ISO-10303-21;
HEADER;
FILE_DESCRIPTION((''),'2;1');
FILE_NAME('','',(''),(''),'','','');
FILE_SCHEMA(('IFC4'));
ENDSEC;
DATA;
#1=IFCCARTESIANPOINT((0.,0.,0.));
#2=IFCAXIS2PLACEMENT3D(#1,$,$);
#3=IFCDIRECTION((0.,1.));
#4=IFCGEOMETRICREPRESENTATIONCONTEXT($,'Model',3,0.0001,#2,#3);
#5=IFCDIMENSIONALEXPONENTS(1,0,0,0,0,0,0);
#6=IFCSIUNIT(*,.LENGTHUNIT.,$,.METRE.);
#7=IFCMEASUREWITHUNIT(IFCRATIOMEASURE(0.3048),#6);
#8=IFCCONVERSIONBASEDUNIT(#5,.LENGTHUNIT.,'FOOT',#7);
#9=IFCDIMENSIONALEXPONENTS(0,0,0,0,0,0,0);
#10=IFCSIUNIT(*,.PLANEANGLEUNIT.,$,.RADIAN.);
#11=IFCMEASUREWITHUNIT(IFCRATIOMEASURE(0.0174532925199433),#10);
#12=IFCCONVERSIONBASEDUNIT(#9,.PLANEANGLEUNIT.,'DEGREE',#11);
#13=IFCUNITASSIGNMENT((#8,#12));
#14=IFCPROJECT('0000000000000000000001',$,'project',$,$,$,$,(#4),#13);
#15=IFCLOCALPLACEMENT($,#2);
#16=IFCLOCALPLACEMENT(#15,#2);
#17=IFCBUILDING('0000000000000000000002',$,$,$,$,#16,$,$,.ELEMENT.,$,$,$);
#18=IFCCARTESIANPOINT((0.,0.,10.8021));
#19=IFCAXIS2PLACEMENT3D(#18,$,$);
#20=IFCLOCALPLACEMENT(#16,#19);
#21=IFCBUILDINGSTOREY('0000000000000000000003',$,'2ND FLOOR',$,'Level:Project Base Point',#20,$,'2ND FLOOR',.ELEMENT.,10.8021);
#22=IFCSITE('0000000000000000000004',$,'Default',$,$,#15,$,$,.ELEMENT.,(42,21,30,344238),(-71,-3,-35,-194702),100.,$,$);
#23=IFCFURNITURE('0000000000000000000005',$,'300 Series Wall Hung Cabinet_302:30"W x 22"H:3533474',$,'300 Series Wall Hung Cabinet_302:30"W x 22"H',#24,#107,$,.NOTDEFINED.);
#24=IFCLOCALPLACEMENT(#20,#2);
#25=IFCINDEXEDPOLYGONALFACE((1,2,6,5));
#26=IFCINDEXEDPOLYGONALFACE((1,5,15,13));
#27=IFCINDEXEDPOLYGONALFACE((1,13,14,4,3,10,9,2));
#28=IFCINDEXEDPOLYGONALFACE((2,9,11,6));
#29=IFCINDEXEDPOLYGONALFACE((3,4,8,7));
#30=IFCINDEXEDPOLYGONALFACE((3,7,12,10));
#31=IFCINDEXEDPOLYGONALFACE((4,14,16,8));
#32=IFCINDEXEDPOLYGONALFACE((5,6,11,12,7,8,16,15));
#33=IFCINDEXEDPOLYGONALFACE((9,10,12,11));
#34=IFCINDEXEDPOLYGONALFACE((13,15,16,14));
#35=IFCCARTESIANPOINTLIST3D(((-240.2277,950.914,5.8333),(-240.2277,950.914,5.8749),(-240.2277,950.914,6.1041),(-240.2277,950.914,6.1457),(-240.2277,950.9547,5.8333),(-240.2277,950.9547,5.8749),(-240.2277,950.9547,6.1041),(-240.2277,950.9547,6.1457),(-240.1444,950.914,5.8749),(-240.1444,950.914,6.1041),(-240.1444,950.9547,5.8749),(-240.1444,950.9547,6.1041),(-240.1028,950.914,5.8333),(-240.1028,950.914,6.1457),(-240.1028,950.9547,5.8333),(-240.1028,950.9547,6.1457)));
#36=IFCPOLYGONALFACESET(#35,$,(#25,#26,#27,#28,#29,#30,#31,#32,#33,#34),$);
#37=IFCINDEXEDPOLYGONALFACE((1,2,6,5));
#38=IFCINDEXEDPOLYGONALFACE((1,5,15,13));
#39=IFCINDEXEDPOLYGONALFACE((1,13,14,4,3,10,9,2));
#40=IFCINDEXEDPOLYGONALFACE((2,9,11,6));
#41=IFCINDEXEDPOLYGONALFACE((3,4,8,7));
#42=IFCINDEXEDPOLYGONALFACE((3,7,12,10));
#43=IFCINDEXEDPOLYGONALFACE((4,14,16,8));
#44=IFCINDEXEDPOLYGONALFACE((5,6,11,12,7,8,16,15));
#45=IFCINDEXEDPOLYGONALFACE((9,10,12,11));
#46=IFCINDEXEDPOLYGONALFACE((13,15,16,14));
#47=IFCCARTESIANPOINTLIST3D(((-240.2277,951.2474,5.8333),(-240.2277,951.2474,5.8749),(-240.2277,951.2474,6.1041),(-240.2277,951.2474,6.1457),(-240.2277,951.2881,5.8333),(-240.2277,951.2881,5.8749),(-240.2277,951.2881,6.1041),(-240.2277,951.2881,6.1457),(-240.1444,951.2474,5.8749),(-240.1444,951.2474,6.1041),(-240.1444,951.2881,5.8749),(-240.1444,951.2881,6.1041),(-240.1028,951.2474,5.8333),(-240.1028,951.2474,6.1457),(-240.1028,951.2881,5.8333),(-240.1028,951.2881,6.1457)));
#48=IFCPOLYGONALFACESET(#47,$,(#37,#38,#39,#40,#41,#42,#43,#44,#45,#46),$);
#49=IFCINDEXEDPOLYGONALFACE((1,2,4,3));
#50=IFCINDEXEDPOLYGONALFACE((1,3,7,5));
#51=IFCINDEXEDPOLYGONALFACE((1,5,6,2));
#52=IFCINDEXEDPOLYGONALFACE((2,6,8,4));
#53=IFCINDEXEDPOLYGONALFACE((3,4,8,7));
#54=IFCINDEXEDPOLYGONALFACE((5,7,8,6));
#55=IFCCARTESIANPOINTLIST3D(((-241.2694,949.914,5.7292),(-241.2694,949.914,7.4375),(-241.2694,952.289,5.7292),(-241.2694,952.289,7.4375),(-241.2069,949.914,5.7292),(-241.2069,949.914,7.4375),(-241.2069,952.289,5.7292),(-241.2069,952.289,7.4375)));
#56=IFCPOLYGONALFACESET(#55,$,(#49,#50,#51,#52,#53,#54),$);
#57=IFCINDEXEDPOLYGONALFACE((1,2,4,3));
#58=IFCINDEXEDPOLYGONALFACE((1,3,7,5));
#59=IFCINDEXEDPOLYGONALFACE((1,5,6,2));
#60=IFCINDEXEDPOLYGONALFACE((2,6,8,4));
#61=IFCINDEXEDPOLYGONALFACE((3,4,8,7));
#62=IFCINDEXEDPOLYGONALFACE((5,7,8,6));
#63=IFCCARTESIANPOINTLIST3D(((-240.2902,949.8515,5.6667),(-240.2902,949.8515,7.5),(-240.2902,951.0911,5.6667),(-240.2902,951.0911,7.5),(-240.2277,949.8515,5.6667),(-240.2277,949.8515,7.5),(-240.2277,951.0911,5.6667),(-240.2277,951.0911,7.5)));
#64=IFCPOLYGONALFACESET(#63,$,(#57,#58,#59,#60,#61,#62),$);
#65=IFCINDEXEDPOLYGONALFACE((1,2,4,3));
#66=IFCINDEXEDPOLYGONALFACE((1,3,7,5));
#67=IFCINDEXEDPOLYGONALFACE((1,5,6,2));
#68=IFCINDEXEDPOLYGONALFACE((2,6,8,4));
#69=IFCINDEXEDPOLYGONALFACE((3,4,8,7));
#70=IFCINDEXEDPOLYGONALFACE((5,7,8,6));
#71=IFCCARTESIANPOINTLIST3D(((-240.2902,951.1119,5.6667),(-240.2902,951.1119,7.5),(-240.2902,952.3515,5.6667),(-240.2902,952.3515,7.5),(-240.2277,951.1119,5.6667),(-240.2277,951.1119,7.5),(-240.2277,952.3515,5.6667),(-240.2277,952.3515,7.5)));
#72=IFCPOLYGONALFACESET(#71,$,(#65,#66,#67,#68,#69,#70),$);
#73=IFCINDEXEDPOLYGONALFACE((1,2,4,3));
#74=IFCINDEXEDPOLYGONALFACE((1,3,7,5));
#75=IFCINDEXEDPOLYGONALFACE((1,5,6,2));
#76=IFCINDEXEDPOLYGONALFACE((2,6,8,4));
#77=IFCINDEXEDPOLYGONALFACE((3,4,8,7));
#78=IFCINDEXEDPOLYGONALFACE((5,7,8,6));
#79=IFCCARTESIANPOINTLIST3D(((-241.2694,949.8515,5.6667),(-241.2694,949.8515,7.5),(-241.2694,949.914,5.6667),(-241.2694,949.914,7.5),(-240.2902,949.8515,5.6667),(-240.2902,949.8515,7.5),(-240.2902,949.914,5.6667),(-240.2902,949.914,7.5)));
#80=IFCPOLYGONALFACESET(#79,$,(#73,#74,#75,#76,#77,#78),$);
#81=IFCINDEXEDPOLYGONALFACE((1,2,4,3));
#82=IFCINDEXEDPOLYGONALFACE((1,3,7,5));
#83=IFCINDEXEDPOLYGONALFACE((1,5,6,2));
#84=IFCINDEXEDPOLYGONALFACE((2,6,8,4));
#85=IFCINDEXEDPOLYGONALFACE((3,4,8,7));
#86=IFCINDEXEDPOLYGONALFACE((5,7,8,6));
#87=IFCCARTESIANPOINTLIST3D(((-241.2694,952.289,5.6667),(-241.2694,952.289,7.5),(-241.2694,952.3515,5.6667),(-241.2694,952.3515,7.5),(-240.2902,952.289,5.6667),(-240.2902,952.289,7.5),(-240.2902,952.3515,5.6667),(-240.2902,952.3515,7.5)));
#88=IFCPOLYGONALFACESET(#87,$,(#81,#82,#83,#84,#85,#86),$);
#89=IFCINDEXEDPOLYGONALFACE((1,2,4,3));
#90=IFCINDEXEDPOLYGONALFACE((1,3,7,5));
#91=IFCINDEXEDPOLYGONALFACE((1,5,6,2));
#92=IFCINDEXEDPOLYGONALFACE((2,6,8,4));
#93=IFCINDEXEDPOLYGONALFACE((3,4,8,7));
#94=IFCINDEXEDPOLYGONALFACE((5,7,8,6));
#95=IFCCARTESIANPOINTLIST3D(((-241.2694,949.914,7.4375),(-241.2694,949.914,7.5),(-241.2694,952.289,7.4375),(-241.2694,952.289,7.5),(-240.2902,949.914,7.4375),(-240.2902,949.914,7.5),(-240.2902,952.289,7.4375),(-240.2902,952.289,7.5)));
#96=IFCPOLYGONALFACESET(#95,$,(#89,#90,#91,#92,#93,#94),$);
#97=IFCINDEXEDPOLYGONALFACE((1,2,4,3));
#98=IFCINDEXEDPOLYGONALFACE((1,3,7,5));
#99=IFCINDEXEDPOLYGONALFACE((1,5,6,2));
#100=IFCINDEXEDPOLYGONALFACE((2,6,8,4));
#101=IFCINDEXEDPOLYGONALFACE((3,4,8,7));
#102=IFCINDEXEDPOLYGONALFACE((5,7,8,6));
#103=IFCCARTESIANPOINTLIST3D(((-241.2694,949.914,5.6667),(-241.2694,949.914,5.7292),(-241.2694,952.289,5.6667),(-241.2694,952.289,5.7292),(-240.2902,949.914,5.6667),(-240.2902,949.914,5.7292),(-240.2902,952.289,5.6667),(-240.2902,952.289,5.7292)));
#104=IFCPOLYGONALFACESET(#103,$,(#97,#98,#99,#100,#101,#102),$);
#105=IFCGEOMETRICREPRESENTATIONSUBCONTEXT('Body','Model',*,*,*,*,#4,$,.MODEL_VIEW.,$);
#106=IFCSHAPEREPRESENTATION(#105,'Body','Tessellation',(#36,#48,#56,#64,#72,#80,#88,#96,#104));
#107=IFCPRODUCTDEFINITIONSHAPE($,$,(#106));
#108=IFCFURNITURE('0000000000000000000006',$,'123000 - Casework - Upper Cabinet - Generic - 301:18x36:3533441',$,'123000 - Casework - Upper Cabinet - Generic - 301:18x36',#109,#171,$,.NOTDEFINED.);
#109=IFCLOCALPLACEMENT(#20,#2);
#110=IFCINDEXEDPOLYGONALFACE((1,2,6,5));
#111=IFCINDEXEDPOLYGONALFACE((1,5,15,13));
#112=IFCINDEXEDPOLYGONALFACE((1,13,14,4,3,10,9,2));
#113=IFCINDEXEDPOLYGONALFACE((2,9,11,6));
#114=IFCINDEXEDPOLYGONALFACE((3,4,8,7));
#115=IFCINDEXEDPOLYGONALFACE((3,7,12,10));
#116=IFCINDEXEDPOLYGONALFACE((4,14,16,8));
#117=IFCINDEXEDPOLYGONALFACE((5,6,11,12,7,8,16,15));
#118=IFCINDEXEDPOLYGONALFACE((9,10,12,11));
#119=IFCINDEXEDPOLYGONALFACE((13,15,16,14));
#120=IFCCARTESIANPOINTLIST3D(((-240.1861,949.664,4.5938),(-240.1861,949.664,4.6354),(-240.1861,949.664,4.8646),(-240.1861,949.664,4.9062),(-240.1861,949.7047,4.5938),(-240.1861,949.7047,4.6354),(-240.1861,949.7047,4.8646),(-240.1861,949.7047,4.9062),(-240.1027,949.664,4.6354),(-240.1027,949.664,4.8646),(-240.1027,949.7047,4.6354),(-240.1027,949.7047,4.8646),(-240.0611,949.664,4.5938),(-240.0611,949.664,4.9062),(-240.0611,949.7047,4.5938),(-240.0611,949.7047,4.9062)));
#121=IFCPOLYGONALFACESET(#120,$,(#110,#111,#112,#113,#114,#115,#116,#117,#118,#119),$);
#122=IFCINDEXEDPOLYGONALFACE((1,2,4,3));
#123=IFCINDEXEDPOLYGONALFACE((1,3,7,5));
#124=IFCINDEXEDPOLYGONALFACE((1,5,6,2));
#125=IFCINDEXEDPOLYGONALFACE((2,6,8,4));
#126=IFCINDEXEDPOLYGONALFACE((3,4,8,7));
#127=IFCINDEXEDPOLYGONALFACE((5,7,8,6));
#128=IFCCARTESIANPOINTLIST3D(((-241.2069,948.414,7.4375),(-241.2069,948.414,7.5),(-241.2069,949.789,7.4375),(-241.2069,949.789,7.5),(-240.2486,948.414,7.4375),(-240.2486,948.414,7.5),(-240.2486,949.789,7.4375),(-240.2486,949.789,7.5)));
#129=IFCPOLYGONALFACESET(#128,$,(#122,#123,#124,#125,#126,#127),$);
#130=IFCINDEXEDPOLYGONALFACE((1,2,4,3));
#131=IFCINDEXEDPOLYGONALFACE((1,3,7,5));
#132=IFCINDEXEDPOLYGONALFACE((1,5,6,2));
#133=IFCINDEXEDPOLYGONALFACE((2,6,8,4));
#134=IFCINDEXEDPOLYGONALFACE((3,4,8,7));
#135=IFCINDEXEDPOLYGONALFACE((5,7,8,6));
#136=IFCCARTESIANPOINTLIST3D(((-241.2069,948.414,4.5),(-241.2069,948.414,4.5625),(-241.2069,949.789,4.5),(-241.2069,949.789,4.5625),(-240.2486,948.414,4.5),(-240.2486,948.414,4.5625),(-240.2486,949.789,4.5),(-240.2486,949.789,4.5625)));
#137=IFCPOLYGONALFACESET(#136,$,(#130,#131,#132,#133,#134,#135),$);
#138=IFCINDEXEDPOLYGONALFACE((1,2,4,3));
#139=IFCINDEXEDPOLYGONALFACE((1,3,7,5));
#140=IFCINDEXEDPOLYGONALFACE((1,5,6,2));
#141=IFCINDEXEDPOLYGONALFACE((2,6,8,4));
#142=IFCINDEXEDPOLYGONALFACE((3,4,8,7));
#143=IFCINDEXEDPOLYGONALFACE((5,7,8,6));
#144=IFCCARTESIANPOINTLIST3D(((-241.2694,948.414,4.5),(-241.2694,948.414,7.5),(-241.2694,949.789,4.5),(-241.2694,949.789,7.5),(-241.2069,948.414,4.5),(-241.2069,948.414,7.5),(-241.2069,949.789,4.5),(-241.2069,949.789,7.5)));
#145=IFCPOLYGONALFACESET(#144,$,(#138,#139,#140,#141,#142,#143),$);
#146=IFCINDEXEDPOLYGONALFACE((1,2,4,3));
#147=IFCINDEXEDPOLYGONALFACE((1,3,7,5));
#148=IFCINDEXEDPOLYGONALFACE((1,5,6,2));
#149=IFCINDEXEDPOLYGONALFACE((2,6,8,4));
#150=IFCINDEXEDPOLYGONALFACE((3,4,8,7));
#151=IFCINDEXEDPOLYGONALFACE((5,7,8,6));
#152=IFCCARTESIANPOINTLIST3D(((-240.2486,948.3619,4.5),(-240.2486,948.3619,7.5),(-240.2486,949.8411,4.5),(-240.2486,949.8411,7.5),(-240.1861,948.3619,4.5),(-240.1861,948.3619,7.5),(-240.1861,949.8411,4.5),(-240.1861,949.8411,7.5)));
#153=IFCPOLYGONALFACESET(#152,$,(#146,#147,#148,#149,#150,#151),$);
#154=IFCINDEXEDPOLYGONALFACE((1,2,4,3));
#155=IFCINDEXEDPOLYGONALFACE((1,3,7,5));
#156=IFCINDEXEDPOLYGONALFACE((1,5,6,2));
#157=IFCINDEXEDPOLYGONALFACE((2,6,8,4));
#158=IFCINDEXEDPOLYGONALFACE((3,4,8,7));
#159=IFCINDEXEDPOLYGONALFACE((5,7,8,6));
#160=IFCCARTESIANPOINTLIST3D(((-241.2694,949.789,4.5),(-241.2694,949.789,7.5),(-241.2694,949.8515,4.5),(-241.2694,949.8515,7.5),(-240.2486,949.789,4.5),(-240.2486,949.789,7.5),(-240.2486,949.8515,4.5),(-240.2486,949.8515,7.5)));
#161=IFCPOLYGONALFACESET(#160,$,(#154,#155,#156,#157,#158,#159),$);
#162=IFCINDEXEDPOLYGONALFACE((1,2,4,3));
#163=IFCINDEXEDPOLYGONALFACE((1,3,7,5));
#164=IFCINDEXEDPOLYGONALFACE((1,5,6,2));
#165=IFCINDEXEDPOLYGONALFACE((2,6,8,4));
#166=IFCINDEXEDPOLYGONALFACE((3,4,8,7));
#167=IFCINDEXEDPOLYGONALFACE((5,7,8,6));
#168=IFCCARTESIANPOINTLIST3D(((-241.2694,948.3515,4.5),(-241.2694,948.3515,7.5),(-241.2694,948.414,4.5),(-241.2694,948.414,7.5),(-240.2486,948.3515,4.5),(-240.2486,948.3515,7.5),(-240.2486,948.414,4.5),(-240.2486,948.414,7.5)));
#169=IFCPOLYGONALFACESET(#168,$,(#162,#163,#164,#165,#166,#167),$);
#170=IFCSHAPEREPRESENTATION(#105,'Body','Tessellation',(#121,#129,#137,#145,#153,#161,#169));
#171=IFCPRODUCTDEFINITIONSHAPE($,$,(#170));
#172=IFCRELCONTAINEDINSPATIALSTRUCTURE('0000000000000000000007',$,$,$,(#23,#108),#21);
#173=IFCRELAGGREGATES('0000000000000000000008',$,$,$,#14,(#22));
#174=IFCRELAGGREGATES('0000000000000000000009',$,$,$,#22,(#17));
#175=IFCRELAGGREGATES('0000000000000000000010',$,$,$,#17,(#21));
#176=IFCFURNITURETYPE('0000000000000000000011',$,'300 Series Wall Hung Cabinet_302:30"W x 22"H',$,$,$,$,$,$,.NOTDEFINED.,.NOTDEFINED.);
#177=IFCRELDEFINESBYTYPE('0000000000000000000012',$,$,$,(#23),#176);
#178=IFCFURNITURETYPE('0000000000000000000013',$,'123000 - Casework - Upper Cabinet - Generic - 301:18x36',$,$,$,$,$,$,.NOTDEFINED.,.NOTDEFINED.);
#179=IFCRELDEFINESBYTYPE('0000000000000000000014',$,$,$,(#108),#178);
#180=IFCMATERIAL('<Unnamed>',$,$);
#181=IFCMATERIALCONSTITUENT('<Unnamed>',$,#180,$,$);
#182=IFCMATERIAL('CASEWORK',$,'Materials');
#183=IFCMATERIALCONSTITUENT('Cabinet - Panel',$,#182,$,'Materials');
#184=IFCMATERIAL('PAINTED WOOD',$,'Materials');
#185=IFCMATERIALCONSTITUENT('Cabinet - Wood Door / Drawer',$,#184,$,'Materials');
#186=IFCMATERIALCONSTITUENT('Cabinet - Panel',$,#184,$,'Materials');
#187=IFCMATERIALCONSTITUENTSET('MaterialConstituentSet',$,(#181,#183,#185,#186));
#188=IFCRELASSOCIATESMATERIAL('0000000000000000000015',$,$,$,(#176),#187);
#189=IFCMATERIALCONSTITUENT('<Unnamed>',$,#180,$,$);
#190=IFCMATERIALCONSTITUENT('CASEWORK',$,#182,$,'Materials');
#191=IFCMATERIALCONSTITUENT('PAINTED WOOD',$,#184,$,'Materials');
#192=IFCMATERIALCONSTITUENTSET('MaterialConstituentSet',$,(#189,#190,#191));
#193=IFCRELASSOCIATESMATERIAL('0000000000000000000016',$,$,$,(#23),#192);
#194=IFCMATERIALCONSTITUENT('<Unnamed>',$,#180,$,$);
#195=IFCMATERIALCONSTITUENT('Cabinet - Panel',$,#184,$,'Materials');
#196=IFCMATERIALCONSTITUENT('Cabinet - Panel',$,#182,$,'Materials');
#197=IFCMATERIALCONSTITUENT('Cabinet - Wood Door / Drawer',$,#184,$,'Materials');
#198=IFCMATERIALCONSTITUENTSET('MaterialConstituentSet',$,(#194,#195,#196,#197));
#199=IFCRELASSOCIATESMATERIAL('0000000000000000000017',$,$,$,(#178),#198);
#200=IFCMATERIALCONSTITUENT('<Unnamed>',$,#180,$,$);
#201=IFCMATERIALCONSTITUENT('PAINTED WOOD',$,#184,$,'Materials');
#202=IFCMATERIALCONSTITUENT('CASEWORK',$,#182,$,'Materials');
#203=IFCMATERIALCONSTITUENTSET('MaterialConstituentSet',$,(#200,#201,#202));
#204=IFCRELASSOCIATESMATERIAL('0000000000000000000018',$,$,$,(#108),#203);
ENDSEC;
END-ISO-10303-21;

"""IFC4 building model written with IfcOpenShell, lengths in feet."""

from ifc_helpers import new_model, entity, si_unit, converted_unit, direction, frame, frame_2d, origin, origin_2d_with_axis, place, context, subcontext, project, spatial, polyline, rectangle, outline, extrude, source, transform, mapped, material, constituent, constituent_set, type_object, type_shapes, element, save


model = new_model("IFC4")

# Units and contexts
model_context = context("Model", 3, precision=0.0001, world=origin(), true_north=direction((0.0, 1.0)))
body_context = subcontext(model_context, "Body", "Model", "MODEL_VIEW")
ifc_project = project(units=[converted_unit("LENGTHUNIT", "FOOT", entity("IfcRatioMeasure", 0.3048), si_unit("LENGTHUNIT", "METRE"), dimensions=[1, 0, 0, 0, 0, 0, 0]), converted_unit("PLANEANGLEUNIT", "DEGREE", entity("IfcRatioMeasure", 0.0174532925199433), si_unit("PLANEANGLEUNIT", "RADIAN"), dimensions=[0, 0, 0, 0, 0, 0, 0])], contexts=[model_context])

# Site, building, storey
site_placement = place(None, origin())
site = spatial("IfcSite", under=ifc_project, at=site_placement, Name="Default", CompositionType="ELEMENT", RefLatitude=(42, 21, 30, 344238), RefLongitude=(-71, -3, -35, -194702), RefElevation=100.0)
building_placement = place(site_placement, origin())
building = spatial("IfcBuilding", under=site, at=building_placement, CompositionType="ELEMENT")
storey_placement = place(building_placement, frame((0.0, 0.0, 10.8021)))
storey = spatial("IfcBuildingStorey", under=building, at=storey_placement, Name="2ND FLOOR", ObjectType="Level:Project Base Point", LongName="2ND FLOOR", CompositionType="ELEMENT", Elevation=10.8021)

# Shared definitions
ifc_material_1 = material(Name="PAINTED WOOD", Category="Materials")
ifc_material_2 = material(Name="CASEWORK", Category="Materials")

# Furniture
ifc_material_3 = material(Name="<Unnamed>")
ifc_constituent_1 = constituent(ifc_material_3, Name="<Unnamed>")
ifc_constituent_2 = constituent(ifc_material_2, Name="CASEWORK", Category="Materials")
ifc_constituent_3 = constituent(ifc_material_1, Name="PAINTED WOOD", Category="Materials")
ifc_constituent_set_1 = constituent_set(constituents=[ifc_constituent_1, ifc_constituent_2, ifc_constituent_3], Name="MaterialConstituentSet")
ifc_constituent_4 = constituent(ifc_material_3, Name="<Unnamed>")
ifc_constituent_5 = constituent(ifc_material_2, Name="Cabinet - Panel", Category="Materials")
ifc_constituent_6 = constituent(ifc_material_1, Name="Cabinet - Wood Door / Drawer", Category="Materials")
ifc_constituent_7 = constituent(ifc_material_1, Name="Cabinet - Panel", Category="Materials")
ifc_constituent_set_2 = constituent_set(constituents=[ifc_constituent_4, ifc_constituent_5, ifc_constituent_6, ifc_constituent_7], Name="MaterialConstituentSet")
furniture_type_1 = type_object("IfcFurnitureType", Name="300 Series Wall Hung Cabinet_302:30\"W x 22\"H", AssemblyPlace="NOTDEFINED", PredefinedType="NOTDEFINED", material=ifc_constituent_set_2)
shared_shape_1 = source(origin(), body_context, "Body", "SweptSolid", [
    extrude(outline(polyline([(0.1146, -0.0521), (0.1562, -0.0521), (0.1562, 0.0729), (-0.1562, 0.0729), (-0.1562, -0.0521), (-0.1146, -0.0521), (-0.1146, 0.0313), (0.1146, 0.0313), (0.1146, -0.0521)])), frame((1.0625, 0.0729, 0.3229), z_axis=(1.0, 0.0, 0.0), x_axis=(0.0, 0.0, 1.0)), (0.0, 0.0, 1.0), 0.0407),
    extrude(outline(polyline([(0.1146, -0.0521), (0.1562, -0.0521), (0.1562, 0.0729), (-0.1562, 0.0729), (-0.1562, -0.0521), (-0.1146, -0.0521), (-0.1146, 0.0313), (0.1146, 0.0313), (0.1146, -0.0521)])), frame((1.3958, 0.0729, 0.3229), z_axis=(1.0, 0.0, 0.0), x_axis=(0.0, 0.0, 1.0)), (0.0, 0.0, 1.0), 0.0407),
    extrude(rectangle(XDim=2.375, YDim=0.0625, at=origin_2d_with_axis()), frame((1.25, 1.1354, 0.0625), z_axis=(0.0, 0.0, 1.0), x_axis=(-1.0, 0.0, 0.0)), (0.0, 0.0, 1.0), 1.7083),
    extrude(rectangle(XDim=1.2396, YDim=0.0625, at=origin_2d_with_axis()), frame((0.6198, 0.1562, 0.0), z_axis=(0.0, 0.0, 1.0), x_axis=(-1.0, 0.0, 0.0)), (0.0, 0.0, 1.0), 1.8333),
    extrude(rectangle(XDim=1.2396, YDim=0.0625, at=frame_2d((0.0, 0.0), x_axis=(1.0, 0.0))), frame((1.8802, 0.1562, 0.0), z_axis=(0.0, 0.0, 1.0), x_axis=(-1.0, 0.0, 0.0)), (0.0, 0.0, 1.0), 1.8333),
    extrude(rectangle(XDim=0.9792, YDim=0.0625, at=frame_2d((0.0, 0.0), x_axis=(1.0, 0.0))), frame((0.0313, 0.677, 0.0), z_axis=(0.0, 0.0, 1.0), x_axis=(0.0, -1.0, 0.0)), (0.0, 0.0, 1.0), 1.8333),
    extrude(rectangle(XDim=0.9792, YDim=0.0625, at=frame_2d((0.0, 0.0), x_axis=(1.0, 0.0))), frame((2.4688, 0.677, 0.0), z_axis=(0.0, 0.0, 1.0), x_axis=(0.0, -1.0, 0.0)), (0.0, 0.0, 1.0), 1.8333),
    extrude(rectangle(XDim=0.9792, YDim=2.375, at=frame_2d((0.0, 0.0), x_axis=(1.0, 0.0))), frame((1.25, 0.677, 1.7708), z_axis=(0.0, 0.0, 1.0), x_axis=(0.0, 1.0, 0.0)), (0.0, 0.0, 1.0), 0.0625),
    extrude(rectangle(XDim=0.9792, YDim=2.375, at=frame_2d((0.0, 0.0), x_axis=(1.0, 0.0))), frame((1.25, 0.677, 0.0), z_axis=(0.0, 0.0, 1.0), x_axis=(0.0, 1.0, 0.0)), (0.0, 0.0, 1.0), 0.0625),
])
type_shapes(furniture_type_1, [shared_shape_1])
furniture_1_placement = place(storey_placement, frame((-240.1028, 949.8515, 5.6667), z_axis=(0.0, 0.0, 1.0), x_axis=(0.0, 1.0, 0.0)))
element("IfcFurniture", 1, at=furniture_1_placement, inside=storey, type_object=furniture_type_1, material=ifc_constituent_set_1, Name="300 Series Wall Hung Cabinet_302:30\"W x 22\"H:3533474", ObjectType="300 Series Wall Hung Cabinet_302:30\"W x 22\"H", PredefinedType="NOTDEFINED", context=body_context, shape_type="MappedRepresentation", body=[
    mapped(shared_shape_1, transform((0.0, 0.0, 0.0), scale=1.0)),
])
ifc_constituent_8 = constituent(ifc_material_3, Name="<Unnamed>")
ifc_constituent_9 = constituent(ifc_material_1, Name="PAINTED WOOD", Category="Materials")
ifc_constituent_10 = constituent(ifc_material_2, Name="CASEWORK", Category="Materials")
ifc_constituent_set_3 = constituent_set(constituents=[ifc_constituent_8, ifc_constituent_9, ifc_constituent_10], Name="MaterialConstituentSet")
ifc_constituent_11 = constituent(ifc_material_3, Name="<Unnamed>")
ifc_constituent_12 = constituent(ifc_material_1, Name="Cabinet - Panel", Category="Materials")
ifc_constituent_13 = constituent(ifc_material_2, Name="Cabinet - Panel", Category="Materials")
ifc_constituent_14 = constituent(ifc_material_1, Name="Cabinet - Wood Door / Drawer", Category="Materials")
ifc_constituent_set_4 = constituent_set(constituents=[ifc_constituent_11, ifc_constituent_12, ifc_constituent_13, ifc_constituent_14], Name="MaterialConstituentSet")
furniture_type_2 = type_object("IfcFurnitureType", Name="123000 - Casework - Upper Cabinet - Generic - 301:18x36", AssemblyPlace="NOTDEFINED", PredefinedType="NOTDEFINED", material=ifc_constituent_set_4)
shared_shape_2 = source(origin(), body_context, "Body", "SweptSolid", [
    extrude(outline(polyline([(-0.0521, -0.1146), (-0.0521, -0.1562), (0.0729, -0.1562), (0.0729, 0.1562), (-0.0521, 0.1562), (-0.0521, 0.1146), (0.0313, 0.1146), (0.0313, -0.1146), (-0.0521, -0.1146)])), frame((0.1468, 1.1354, 0.25), z_axis=(-1.0, 0.0, 0.0), x_axis=(0.0, 1.0, 0.0)), (0.0, 0.0, -1.0), 0.0407),
    extrude(rectangle(XDim=0.9583, YDim=1.375, at=frame_2d((0.0, 0.0), x_axis=(1.0, 0.0))), frame((0.75, 0.5417, 2.9375), z_axis=(0.0, 0.0, 1.0), x_axis=(0.0, 1.0, 0.0)), (0.0, 0.0, 1.0), 0.0625),
    extrude(rectangle(XDim=0.9583, YDim=1.375, at=frame_2d((0.0, 0.0), x_axis=(1.0, 0.0))), frame((0.75, 0.5417, 0.0), z_axis=(0.0, 0.0, 1.0), x_axis=(0.0, 1.0, 0.0)), (0.0, 0.0, 1.0), 0.0625),
    extrude(rectangle(XDim=1.375, YDim=0.0625, at=origin_2d_with_axis()), frame((0.75, 0.0313, 0.0), z_axis=(0.0, 0.0, 1.0), x_axis=(-1.0, 0.0, 0.0)), (0.0, 0.0, 1.0), 3.0),
    extrude(rectangle(XDim=1.4792, YDim=0.0625, at=origin_2d_with_axis()), frame((0.75, 1.0521, 0.0)), (0.0, 0.0, 1.0), 3.0),
    extrude(rectangle(XDim=1.0208, YDim=0.0625, at=origin_2d_with_axis()), frame((0.0312, 0.5104, 0.0), z_axis=(0.0, 0.0, 1.0), x_axis=(0.0, 1.0, 0.0)), (0.0, 0.0, 1.0), 3.0),
    extrude(rectangle(XDim=1.0208, YDim=0.0625, at=origin_2d_with_axis()), frame((1.4688, 0.5104, 0.0), z_axis=(0.0, 0.0, 1.0), x_axis=(0.0, 1.0, 0.0)), (0.0, 0.0, 1.0), 3.0),
])
type_shapes(furniture_type_2, [shared_shape_2])
furniture_2_placement = place(storey_placement, frame((-241.2694, 949.8515, 4.5), z_axis=(0.0, 0.0, 1.0), x_axis=(0.0, -1.0, 0.0)))
element("IfcFurniture", 2, at=furniture_2_placement, inside=storey, type_object=furniture_type_2, material=ifc_constituent_set_3, Name="123000 - Casework - Upper Cabinet - Generic - 301:18x36:3533441", ObjectType="123000 - Casework - Upper Cabinet - Generic - 301:18x36", PredefinedType="NOTDEFINED", context=body_context, shape_type="MappedRepresentation", body=[
    mapped(shared_shape_2, transform((0.0, 0.0, 0.0), scale=1.0)),
])

save(model, "model.ifc")
